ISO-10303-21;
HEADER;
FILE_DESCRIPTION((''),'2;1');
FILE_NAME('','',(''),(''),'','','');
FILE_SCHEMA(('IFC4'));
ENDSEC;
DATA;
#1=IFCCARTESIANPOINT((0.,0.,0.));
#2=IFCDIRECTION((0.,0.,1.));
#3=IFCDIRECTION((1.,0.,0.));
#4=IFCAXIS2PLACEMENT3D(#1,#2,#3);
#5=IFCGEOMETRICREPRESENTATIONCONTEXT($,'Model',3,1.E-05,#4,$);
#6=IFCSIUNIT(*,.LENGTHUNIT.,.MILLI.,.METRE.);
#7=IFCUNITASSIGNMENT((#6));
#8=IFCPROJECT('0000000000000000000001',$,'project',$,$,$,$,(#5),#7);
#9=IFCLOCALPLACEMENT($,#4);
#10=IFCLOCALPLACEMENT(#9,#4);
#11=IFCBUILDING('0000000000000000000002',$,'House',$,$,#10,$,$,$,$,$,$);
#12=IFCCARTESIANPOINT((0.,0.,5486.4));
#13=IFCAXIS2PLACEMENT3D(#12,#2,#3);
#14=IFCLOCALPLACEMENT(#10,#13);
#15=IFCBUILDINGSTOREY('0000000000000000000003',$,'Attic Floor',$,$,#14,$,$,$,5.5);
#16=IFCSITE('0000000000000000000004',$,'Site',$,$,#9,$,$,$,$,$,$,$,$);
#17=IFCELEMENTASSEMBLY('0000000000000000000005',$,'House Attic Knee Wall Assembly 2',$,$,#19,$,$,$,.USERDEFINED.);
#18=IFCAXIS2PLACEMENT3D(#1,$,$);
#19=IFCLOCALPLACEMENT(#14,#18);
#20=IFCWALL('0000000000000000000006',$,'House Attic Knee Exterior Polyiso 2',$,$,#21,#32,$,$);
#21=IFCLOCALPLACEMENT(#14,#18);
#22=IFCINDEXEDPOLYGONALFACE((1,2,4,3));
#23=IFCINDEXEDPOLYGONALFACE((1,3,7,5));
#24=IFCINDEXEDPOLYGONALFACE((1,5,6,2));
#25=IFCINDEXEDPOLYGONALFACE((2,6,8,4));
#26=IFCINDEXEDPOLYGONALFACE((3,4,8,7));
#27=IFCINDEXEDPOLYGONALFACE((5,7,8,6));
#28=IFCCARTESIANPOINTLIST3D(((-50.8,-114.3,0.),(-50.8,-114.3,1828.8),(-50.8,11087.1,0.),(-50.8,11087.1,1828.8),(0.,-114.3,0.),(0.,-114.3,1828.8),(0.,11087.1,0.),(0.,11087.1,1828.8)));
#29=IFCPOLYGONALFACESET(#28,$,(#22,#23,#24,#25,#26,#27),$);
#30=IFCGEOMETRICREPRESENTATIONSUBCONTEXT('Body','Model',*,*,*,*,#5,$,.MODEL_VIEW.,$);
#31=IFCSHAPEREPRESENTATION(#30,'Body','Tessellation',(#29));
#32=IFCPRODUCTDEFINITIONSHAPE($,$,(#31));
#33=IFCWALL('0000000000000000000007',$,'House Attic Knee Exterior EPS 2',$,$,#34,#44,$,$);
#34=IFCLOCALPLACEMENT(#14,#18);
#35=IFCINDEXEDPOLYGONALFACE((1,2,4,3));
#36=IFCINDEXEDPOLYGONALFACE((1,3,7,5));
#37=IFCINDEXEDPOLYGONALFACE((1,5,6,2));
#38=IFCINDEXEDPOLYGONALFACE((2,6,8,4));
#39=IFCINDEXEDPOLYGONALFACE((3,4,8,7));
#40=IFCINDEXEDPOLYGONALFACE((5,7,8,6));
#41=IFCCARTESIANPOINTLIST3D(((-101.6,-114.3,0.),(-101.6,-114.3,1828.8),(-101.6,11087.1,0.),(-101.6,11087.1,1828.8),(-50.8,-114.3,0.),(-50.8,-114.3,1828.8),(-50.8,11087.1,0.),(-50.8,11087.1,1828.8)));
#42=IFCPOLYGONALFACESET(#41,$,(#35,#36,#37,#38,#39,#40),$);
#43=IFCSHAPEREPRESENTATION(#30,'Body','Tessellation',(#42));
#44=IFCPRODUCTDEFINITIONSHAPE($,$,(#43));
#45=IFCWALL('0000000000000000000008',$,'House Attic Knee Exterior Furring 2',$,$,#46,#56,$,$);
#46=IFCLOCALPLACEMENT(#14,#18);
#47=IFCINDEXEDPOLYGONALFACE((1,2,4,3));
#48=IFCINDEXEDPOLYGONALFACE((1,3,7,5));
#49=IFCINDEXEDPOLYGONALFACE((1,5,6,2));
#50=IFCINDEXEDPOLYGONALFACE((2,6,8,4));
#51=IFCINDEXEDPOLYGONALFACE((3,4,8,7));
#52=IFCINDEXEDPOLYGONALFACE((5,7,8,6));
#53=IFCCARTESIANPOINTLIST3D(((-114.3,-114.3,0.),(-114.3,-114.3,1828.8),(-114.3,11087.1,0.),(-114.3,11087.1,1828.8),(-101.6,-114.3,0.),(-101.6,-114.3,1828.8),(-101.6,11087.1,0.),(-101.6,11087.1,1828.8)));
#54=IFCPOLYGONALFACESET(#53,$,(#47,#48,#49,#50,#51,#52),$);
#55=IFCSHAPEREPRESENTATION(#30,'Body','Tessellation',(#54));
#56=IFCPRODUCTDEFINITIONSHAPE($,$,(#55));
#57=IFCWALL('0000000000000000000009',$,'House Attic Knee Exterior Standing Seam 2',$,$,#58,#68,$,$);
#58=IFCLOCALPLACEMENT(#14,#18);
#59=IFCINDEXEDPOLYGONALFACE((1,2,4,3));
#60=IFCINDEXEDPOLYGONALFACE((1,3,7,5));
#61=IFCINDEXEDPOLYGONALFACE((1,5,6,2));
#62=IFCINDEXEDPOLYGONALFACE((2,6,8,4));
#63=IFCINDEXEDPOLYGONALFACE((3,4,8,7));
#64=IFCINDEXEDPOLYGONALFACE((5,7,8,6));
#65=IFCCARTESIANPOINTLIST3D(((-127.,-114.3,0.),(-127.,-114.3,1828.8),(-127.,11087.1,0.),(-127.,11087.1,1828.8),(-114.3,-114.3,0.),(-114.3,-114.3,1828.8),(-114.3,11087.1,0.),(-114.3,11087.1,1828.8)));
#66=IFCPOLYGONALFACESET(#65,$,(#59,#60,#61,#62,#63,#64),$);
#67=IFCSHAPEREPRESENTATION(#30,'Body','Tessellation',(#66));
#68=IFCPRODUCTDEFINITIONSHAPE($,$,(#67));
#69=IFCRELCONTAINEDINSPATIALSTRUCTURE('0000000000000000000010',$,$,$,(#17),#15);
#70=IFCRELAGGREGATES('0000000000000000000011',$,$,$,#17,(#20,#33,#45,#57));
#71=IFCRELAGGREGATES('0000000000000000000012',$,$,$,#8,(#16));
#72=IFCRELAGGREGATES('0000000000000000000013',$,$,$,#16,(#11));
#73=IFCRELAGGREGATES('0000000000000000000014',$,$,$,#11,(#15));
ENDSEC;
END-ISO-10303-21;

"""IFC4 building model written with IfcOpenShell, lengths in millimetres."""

from ifc_helpers import new_model, si_unit, frame, origin_with_axes, place, context, subcontext, project, spatial, indexed_curve, outline, extrude, element, aggregate, save


model = new_model("IFC4")

# Units and contexts
model_context = context("Model", 3, precision=1e-05, world=origin_with_axes())
body_context = subcontext(model_context, "Body", "Model", "MODEL_VIEW")
ifc_project = project(units=[si_unit("LENGTHUNIT", "METRE", prefix="MILLI")], contexts=[model_context])

# Site, building, storey
site_placement = place(None, origin_with_axes())
site = spatial("IfcSite", under=ifc_project, at=site_placement, Name="Site")
building_placement = place(site_placement, origin_with_axes())
building = spatial("IfcBuilding", under=site, at=building_placement, Name="House")
storey_placement = place(building_placement, frame((0.0, 0.0, 5486.4), z_axis=(0.0, 0.0, 1.0), x_axis=(1.0, 0.0, 0.0)))
storey = spatial("IfcBuildingStorey", under=building, at=storey_placement, Name="Attic Floor", Elevation=5.5)

# Element assembly
assembly_1_placement = place(storey_placement, frame((0.0, 0.0, -5486.4), z_axis=(0.0, 0.0, 1.0), x_axis=(1.0, 0.0, 0.0)))
assembly_1 = element("IfcElementAssembly", 1, at=assembly_1_placement, inside=storey, Name="House Attic Knee Wall Assembly 2", PredefinedType="USERDEFINED")

# Walls
wall_1_placement = place(assembly_1_placement, frame((0.0, 11087.1, 5486.4), z_axis=(0.0, 0.0, 1.0), x_axis=(0.0, -1.0, 0.0)))
wall_1 = element("IfcWall", 2, at=wall_1_placement, Name="House Attic Knee Exterior Polyiso 2", context=body_context, shape_type="SweptSolid", body=[
    extrude(outline(indexed_curve([(0.0, 0.0), (0.0, -50.8), (11201.4, -50.8), (11201.4, 0.0), (0.0, 0.0)], self_intersect=False)), origin_with_axes(), (0.0, 0.0, 1.0), 1828.8),
])
wall_2_placement = place(assembly_1_placement, frame((0.0, 11087.1, 5486.4), z_axis=(0.0, 0.0, 1.0), x_axis=(0.0, -1.0, 0.0)))
wall_2 = element("IfcWall", 3, at=wall_2_placement, Name="House Attic Knee Exterior EPS 2", context=body_context, shape_type="SweptSolid", body=[
    extrude(outline(indexed_curve([(0.0, 0.0), (0.0, -50.8), (11201.4, -50.8), (11201.4, 0.0), (0.0, 0.0)], self_intersect=False)), frame((0.0, -50.8, 0.0), z_axis=(0.0, 0.0, 1.0), x_axis=(1.0, 0.0, 0.0)), (0.0, 0.0, 1.0), 1828.8),
])
wall_3_placement = place(assembly_1_placement, frame((0.0, 11087.1, 5486.4), z_axis=(0.0, 0.0, 1.0), x_axis=(0.0, -1.0, 0.0)))
wall_3 = element("IfcWall", 4, at=wall_3_placement, Name="House Attic Knee Exterior Furring 2", context=body_context, shape_type="SweptSolid", body=[
    extrude(outline(indexed_curve([(0.0, 0.0), (0.0, -12.7), (11201.4, -12.7), (11201.4, 0.0), (0.0, 0.0)], self_intersect=False)), frame((0.0, -101.6, 0.0), z_axis=(0.0, 0.0, 1.0), x_axis=(1.0, 0.0, 0.0)), (0.0, 0.0, 1.0), 1828.8),
])
wall_4_placement = place(assembly_1_placement, frame((0.0, 11087.1, 5486.4), z_axis=(0.0, 0.0, 1.0), x_axis=(0.0, -1.0, 0.0)))
wall_4 = element("IfcWall", 5, at=wall_4_placement, Name="House Attic Knee Exterior Standing Seam 2", context=body_context, shape_type="SweptSolid", body=[
    extrude(outline(indexed_curve([(0.0, 0.0), (0.0, -12.7), (11201.4, -12.7), (11201.4, 0.0), (0.0, 0.0)], self_intersect=False)), frame((0.0, -114.3, 0.0), z_axis=(0.0, 0.0, 1.0), x_axis=(1.0, 0.0, 0.0)), (0.0, 0.0, 1.0), 1828.8),
])
aggregate(assembly_1, [wall_1, wall_2, wall_3, wall_4])

save(model, "model.ifc")
